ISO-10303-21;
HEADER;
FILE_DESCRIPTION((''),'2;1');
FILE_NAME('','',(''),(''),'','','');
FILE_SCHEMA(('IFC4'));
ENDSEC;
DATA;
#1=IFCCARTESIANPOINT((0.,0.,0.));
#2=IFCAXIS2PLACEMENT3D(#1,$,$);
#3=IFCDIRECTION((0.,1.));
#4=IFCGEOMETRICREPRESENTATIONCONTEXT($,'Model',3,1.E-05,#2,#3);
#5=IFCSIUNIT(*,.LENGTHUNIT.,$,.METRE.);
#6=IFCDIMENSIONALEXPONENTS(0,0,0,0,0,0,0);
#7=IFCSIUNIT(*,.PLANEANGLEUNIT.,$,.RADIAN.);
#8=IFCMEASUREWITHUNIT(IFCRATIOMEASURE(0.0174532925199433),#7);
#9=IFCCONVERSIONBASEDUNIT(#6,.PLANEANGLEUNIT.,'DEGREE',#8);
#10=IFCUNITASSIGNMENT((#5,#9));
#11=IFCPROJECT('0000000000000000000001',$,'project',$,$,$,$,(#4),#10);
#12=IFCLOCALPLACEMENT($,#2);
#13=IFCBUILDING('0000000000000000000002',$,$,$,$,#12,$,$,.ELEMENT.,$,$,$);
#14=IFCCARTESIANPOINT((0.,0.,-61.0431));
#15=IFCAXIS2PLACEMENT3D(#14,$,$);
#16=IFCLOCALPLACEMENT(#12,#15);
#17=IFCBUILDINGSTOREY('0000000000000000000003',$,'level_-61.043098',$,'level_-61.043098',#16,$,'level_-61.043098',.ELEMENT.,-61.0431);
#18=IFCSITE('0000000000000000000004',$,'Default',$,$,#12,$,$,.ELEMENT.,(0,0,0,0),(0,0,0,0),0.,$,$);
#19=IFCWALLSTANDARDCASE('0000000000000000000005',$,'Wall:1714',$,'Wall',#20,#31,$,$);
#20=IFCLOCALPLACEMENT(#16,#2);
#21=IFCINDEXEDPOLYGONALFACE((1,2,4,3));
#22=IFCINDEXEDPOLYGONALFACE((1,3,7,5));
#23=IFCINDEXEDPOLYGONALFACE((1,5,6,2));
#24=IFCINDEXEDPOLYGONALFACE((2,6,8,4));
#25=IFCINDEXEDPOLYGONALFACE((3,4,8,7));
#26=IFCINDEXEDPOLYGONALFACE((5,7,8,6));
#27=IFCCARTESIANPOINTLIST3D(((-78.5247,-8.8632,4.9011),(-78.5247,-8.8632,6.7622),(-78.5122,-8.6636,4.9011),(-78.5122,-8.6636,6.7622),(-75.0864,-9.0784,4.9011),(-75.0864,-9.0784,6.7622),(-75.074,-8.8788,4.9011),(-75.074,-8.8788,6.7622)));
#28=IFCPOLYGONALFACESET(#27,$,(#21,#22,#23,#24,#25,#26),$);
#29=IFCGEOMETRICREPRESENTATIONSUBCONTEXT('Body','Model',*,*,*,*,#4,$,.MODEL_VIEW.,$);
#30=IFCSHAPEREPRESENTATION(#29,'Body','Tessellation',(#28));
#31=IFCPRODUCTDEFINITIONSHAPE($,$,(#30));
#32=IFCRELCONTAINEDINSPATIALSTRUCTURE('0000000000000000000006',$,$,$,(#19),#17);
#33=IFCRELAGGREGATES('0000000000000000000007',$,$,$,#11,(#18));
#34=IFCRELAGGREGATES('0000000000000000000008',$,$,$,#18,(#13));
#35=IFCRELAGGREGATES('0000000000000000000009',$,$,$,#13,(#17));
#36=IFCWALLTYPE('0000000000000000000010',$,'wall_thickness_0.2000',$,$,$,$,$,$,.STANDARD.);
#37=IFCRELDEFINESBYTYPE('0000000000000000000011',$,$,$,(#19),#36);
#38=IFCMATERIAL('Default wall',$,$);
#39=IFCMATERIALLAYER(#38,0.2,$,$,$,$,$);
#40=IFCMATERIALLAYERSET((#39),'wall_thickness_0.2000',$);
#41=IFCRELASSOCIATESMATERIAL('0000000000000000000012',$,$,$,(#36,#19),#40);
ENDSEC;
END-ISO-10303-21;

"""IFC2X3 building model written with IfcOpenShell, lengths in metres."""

from ifc_helpers import new_model, entity, si_unit, converted_unit, direction, frame, origin, place, context, subcontext, project, spatial, polyline, outline, extrude, material, layer, layer_set, layer_usage, type_object, element, save


model = new_model("IFC2X3")

# Units and contexts
model_context = context("Model", 3, precision=1e-05, world=origin(), true_north=direction((0.0, 1.0)))
body_context = subcontext(model_context, "Body", "Model", "MODEL_VIEW")
ifc_project = project(units=[si_unit("LENGTHUNIT", "METRE"), converted_unit("PLANEANGLEUNIT", "DEGREE", entity("IfcRatioMeasure", 0.0174532925199433), si_unit("PLANEANGLEUNIT", "RADIAN"), dimensions=[0, 0, 0, 0, 0, 0, 0])], contexts=[model_context])

# Site, building, storey
placement_1 = place(None, origin())
site = spatial("IfcSite", under=ifc_project, at=placement_1, Name="Default", CompositionType="ELEMENT", RefLatitude=(0, 0, 0, 0), RefLongitude=(0, 0, 0, 0), RefElevation=0.0)
building = spatial("IfcBuilding", under=site, at=placement_1, CompositionType="ELEMENT")
storey_placement = place(placement_1, frame((0.0, 0.0, -61.0431)))
storey = spatial("IfcBuildingStorey", under=building, at=storey_placement, Name="level_-61.043098", ObjectType="level_-61.043098", LongName="level_-61.043098", CompositionType="ELEMENT", Elevation=-61.0431)

# Wall
ifc_material = material(Name="Default wall")
ifc_layer = layer(ifc_material, 0.2)
ifc_layer_set = layer_set([ifc_layer], Name="wall_thickness_0.2000")
ifc_layer_usage = layer_usage(ifc_layer_set, "AXIS2", "POSITIVE", -0.1)
wall_type = type_object("IfcWallType", Name="wall_thickness_0.2000", PredefinedType="STANDARD", material=ifc_layer_set)
placement_2 = place(placement_1, frame((0.0, 0.0, -56.142)))
wall_placement = place(placement_2, frame((-78.5185, -8.7634, 0.0), z_axis=(0.0, 0.0, 1.0), x_axis=(0.998046, -0.06249, 0.0)))
element("IfcWallStandardCase", 1, at=wall_placement, inside=storey, type_object=wall_type, material=ifc_layer_usage, Name="Wall:1714", ObjectType="Wall", context=body_context, shape_type="SweptSolid", body=[
    extrude(outline(polyline([(3.445, -0.1), (3.445, 0.1), (0.0, 0.1), (0.0, -0.1), (3.445, -0.1)])), origin(), (0.0, 0.0, 1.0), 1.8611),
])

save(model, "model.ifc")
